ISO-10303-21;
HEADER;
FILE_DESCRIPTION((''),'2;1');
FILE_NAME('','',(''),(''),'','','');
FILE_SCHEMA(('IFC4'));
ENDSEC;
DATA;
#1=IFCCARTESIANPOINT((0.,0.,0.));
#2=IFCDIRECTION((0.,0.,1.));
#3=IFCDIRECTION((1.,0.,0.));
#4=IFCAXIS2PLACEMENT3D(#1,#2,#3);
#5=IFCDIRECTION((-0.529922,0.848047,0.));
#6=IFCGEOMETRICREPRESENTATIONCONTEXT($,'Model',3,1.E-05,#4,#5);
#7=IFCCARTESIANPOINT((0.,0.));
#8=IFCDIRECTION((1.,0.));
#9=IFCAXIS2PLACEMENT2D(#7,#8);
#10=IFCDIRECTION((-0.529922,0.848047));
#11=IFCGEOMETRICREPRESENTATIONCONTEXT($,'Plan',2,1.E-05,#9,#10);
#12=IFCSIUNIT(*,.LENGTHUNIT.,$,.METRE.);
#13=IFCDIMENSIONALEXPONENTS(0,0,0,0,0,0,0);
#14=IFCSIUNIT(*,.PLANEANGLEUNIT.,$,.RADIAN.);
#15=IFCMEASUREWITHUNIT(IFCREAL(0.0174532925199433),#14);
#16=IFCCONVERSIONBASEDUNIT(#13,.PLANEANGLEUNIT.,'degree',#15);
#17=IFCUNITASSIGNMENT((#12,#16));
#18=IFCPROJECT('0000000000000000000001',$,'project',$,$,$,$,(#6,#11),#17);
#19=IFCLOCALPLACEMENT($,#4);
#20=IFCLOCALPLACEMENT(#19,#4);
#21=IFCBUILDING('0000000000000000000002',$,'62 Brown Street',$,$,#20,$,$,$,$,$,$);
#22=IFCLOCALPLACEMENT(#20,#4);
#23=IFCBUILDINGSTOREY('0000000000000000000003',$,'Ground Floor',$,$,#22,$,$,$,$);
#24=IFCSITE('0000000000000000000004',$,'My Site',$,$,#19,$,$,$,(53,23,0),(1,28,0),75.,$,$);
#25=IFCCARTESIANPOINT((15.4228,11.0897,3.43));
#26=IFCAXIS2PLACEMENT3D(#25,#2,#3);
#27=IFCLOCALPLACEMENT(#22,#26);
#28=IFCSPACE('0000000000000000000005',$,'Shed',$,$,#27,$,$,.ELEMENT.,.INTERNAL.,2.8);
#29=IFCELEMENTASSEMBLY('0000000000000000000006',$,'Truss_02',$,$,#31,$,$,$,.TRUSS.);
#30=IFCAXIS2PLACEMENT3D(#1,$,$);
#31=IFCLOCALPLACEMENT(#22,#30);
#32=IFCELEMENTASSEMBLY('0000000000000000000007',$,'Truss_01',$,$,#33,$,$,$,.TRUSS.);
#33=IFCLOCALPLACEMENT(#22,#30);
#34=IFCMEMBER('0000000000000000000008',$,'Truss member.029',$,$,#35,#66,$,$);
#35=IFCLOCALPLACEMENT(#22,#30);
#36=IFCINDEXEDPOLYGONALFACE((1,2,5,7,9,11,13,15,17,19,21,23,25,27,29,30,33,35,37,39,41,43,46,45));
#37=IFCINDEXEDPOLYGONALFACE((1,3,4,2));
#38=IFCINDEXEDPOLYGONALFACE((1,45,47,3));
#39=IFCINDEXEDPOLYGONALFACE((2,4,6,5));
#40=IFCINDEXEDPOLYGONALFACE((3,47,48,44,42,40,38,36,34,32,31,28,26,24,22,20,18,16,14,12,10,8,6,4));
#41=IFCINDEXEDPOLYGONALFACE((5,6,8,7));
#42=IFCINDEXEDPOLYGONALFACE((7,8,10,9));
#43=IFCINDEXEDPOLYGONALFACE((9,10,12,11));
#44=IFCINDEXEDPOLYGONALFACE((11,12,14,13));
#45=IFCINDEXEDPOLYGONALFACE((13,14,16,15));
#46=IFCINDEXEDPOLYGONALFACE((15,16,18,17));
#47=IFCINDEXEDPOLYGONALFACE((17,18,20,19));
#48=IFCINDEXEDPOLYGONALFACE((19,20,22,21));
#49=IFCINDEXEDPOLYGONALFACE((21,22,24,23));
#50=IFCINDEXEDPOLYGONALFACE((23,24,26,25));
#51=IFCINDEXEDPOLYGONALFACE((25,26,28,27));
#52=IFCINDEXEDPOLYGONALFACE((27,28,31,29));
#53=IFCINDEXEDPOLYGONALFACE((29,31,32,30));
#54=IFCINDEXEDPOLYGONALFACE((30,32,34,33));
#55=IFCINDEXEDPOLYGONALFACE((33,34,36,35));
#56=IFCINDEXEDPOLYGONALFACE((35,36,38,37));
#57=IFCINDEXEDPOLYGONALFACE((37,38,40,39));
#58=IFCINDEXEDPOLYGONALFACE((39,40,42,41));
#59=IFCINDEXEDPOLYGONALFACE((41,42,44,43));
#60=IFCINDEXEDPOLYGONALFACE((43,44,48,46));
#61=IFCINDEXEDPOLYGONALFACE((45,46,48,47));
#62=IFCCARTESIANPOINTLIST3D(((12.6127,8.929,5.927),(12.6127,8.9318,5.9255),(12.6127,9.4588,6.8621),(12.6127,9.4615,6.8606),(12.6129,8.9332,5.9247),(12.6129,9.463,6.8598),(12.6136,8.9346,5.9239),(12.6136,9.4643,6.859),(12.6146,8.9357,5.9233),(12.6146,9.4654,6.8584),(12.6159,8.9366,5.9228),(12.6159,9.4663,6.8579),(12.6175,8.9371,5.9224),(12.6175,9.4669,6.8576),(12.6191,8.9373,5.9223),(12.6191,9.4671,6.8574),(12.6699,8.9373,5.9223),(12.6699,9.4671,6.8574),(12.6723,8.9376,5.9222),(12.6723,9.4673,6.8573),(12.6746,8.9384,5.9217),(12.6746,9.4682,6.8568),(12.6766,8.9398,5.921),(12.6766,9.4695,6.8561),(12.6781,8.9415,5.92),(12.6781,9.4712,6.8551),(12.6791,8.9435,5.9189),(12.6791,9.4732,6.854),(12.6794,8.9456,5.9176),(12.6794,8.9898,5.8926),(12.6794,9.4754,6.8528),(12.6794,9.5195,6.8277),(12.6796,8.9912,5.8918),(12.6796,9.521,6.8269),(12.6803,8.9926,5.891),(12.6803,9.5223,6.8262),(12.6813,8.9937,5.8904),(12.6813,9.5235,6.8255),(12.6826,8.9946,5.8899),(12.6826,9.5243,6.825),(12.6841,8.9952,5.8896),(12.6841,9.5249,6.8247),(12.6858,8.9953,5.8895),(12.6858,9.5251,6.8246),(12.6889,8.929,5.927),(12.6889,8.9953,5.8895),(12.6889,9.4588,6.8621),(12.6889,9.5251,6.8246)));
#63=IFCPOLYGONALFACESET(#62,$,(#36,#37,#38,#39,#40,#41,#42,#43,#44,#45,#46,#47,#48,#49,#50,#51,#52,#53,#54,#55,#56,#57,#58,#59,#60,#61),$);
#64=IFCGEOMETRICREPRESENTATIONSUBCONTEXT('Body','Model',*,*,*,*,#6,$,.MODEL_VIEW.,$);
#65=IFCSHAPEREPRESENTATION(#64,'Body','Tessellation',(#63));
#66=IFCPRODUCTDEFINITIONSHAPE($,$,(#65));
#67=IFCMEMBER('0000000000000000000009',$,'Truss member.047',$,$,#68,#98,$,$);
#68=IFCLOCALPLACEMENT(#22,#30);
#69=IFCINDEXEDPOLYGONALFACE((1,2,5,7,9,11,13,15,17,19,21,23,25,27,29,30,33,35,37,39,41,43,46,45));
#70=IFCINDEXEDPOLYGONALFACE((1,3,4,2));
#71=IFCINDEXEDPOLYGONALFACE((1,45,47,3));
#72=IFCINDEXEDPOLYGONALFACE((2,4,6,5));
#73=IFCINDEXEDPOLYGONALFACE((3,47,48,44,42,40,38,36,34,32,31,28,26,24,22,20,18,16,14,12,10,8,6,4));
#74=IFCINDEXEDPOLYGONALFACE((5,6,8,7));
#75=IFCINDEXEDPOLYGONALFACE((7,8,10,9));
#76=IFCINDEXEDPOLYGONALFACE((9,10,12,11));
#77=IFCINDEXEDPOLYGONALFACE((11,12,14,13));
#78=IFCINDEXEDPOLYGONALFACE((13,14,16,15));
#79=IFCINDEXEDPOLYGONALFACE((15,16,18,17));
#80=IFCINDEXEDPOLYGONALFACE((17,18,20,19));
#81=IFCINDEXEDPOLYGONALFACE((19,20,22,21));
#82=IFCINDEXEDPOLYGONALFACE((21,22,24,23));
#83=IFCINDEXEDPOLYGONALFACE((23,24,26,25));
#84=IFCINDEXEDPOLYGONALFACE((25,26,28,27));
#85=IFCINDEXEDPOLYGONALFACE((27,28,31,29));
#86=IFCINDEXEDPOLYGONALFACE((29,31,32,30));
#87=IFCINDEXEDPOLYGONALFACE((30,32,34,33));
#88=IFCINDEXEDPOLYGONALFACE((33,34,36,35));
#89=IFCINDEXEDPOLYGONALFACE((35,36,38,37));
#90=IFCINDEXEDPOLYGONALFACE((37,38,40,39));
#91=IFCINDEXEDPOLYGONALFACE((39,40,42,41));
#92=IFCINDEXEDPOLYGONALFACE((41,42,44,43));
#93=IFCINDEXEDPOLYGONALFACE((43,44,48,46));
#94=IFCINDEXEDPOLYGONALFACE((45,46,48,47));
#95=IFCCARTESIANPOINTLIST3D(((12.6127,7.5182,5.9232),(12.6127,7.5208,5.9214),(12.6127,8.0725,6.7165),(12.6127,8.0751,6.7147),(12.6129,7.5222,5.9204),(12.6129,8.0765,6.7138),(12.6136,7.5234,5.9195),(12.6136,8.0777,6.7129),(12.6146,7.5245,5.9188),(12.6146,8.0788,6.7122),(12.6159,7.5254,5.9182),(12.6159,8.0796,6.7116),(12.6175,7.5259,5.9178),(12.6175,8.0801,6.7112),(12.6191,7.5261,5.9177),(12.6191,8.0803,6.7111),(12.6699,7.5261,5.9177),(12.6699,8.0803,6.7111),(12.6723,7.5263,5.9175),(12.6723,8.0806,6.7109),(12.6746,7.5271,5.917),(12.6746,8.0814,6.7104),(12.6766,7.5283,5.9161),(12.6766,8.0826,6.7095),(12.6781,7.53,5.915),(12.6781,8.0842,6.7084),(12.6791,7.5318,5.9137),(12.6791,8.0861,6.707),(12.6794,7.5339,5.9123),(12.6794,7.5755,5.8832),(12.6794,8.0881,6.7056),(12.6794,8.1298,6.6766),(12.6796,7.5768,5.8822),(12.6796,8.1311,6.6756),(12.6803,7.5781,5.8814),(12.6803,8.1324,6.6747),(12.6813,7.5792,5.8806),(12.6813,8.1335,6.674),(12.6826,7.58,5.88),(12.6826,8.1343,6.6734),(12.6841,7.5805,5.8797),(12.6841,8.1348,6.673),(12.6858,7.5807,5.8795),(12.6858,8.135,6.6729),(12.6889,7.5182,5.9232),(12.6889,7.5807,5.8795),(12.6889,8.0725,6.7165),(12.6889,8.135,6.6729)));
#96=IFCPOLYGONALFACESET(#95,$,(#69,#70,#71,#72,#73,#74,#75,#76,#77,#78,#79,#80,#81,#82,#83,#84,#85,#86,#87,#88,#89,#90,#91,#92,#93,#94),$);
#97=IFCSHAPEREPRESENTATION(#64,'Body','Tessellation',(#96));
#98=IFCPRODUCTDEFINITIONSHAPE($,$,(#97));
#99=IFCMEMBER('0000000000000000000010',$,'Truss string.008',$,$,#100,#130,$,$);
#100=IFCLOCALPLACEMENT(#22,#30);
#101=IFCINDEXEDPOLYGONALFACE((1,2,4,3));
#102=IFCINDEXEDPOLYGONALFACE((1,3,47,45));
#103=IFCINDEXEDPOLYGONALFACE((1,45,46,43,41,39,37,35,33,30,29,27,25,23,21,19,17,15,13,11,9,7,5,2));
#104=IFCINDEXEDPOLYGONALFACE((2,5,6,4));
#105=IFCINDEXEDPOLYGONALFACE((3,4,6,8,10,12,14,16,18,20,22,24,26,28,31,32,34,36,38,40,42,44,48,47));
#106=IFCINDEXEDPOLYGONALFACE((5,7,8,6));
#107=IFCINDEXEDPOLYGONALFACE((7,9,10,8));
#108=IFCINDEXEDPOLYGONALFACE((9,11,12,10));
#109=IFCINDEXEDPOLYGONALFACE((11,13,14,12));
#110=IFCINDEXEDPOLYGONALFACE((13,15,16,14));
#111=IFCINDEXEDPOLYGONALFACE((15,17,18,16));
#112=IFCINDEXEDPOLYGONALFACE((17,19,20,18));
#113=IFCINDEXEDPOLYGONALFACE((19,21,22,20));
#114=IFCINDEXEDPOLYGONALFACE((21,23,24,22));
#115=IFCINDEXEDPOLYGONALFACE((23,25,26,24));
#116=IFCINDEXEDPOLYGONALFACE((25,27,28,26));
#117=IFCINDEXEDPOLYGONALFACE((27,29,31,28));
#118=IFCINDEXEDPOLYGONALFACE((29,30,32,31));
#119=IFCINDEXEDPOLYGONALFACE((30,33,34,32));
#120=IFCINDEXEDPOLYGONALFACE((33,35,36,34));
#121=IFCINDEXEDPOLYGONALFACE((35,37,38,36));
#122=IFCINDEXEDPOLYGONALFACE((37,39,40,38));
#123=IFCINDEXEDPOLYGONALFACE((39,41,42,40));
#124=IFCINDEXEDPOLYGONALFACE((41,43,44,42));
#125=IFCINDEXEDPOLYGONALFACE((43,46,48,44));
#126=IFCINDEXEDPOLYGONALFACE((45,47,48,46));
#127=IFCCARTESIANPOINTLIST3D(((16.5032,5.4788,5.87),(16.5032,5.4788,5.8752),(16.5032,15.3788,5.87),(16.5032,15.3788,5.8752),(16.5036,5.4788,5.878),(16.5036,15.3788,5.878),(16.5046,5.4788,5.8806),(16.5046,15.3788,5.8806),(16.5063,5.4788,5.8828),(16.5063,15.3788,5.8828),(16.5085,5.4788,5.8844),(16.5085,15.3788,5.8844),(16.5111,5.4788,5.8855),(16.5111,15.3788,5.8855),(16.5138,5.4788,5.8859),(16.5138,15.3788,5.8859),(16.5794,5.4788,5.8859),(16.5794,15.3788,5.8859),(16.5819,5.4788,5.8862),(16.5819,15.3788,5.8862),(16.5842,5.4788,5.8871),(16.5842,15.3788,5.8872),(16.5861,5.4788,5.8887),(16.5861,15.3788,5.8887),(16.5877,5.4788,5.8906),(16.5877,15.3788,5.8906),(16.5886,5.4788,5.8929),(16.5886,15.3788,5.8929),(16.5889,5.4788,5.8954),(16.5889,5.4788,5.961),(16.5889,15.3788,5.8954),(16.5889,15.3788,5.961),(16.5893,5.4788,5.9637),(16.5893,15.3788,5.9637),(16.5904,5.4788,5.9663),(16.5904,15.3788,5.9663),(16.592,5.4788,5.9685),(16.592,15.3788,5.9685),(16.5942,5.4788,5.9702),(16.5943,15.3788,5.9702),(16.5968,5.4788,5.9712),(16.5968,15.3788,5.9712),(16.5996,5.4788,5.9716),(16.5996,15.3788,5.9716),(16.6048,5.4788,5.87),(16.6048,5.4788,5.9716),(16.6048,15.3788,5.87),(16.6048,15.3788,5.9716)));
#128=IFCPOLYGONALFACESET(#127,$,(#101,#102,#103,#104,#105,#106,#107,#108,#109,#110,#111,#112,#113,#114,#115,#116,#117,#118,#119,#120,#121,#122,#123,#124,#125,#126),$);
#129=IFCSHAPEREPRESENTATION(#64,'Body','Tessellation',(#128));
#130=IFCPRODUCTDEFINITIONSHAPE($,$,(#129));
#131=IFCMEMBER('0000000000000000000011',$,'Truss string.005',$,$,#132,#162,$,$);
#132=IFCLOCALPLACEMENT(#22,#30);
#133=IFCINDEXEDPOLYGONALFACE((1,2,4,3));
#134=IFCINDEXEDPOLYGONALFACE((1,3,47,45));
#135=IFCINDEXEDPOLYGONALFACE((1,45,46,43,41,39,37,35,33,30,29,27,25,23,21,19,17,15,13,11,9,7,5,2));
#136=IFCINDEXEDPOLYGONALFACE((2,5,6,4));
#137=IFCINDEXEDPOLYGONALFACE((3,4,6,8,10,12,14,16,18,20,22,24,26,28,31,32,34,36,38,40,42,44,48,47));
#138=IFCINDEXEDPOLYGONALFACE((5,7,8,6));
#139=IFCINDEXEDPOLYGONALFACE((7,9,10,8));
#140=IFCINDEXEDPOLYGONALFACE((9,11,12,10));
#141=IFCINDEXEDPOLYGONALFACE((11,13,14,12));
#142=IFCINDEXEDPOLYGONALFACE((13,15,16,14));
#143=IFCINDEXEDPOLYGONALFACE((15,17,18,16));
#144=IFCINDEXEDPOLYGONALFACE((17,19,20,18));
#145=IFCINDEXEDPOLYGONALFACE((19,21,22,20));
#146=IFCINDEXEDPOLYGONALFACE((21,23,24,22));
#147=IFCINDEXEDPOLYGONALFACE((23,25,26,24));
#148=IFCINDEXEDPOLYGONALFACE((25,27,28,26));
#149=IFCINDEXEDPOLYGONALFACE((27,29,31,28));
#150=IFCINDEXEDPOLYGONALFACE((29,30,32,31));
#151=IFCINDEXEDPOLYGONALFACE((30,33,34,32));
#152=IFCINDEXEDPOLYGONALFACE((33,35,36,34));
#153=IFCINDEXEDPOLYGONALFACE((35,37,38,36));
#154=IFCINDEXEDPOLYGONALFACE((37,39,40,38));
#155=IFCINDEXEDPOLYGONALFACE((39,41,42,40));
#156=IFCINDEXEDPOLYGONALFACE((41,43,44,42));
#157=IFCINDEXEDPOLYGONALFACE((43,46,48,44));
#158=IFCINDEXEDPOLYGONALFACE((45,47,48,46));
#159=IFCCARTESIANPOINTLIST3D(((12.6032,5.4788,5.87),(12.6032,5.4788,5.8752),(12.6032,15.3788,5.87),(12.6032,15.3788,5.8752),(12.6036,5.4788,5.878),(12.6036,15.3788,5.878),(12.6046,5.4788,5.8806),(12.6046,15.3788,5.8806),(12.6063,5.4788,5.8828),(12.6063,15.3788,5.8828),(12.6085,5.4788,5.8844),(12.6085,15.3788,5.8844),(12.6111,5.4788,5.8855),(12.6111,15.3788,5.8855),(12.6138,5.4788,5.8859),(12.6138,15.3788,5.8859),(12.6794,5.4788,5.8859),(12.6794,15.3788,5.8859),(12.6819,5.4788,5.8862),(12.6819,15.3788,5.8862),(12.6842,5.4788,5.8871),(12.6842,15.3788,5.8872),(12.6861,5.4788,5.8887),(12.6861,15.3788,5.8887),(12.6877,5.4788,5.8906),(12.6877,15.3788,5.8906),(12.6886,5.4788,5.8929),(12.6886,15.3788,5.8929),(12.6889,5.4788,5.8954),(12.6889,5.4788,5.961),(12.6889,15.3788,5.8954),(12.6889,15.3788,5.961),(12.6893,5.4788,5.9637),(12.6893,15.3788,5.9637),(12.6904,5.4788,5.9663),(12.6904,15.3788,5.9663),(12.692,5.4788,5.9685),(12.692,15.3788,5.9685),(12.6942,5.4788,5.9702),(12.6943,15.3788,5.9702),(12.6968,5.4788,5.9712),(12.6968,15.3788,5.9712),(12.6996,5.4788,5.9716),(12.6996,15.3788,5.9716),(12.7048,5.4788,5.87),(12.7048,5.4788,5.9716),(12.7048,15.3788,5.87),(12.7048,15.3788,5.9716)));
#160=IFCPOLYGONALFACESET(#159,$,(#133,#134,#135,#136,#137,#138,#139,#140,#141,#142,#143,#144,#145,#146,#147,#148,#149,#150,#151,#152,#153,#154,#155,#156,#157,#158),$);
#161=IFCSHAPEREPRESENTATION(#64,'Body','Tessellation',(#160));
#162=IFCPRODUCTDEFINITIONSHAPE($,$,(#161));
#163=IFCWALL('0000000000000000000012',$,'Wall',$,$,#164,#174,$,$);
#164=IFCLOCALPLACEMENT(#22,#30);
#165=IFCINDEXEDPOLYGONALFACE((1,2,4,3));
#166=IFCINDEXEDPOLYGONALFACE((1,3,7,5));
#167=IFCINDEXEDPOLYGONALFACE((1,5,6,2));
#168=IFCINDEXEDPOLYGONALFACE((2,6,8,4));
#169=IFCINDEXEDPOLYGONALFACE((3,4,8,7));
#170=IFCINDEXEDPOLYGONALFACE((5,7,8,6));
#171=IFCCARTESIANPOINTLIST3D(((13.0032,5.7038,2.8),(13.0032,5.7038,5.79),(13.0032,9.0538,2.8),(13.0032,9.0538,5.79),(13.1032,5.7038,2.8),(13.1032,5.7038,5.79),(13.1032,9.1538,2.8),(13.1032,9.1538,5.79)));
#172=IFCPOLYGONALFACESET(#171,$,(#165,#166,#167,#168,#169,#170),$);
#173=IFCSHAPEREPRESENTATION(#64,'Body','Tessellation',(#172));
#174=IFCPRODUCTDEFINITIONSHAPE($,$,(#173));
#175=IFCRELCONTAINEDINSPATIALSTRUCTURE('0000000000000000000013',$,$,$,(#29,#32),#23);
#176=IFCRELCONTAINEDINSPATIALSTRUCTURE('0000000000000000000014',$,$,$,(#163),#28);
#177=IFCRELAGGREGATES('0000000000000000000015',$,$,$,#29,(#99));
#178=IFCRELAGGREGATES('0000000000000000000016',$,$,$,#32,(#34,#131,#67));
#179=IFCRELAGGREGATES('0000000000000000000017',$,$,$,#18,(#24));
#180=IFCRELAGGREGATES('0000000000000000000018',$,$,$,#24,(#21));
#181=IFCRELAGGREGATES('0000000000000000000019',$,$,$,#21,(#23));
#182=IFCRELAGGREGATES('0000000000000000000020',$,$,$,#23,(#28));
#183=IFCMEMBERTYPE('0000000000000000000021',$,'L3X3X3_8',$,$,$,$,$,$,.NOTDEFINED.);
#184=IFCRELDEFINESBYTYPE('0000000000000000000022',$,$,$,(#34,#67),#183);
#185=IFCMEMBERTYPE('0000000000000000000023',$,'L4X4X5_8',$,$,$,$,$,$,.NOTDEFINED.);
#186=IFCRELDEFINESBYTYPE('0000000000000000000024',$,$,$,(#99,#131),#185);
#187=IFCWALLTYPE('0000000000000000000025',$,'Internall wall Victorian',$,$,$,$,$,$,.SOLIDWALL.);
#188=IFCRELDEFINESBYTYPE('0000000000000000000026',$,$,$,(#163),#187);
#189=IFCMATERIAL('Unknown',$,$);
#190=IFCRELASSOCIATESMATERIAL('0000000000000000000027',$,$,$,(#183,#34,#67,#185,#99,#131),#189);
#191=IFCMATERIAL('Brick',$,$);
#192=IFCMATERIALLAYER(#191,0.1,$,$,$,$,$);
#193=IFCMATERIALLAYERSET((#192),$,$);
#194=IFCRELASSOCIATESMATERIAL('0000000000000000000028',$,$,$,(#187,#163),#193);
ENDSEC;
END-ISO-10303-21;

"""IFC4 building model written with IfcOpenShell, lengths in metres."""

from ifc_helpers import new_model, entity, si_unit, converted_unit, direction, frame, origin_with_axes, origin_2d_with_axis, place, context, subcontext, project, spatial, indexed_curve, l_section, outline, extrude, clip, halfspace, material, layer, layer_set, layer_usage, material_profile, profile_set, profile_usage, type_object, element, aggregate, save


model = new_model("IFC4")

# Units and contexts
model_context = context("Model", 3, precision=1e-05, world=origin_with_axes(), true_north=direction((-0.529922, 0.848047, 0.0)))
plan_context = context("Plan", 2, precision=1e-05, world=origin_2d_with_axis(), true_north=direction((-0.529922, 0.848047)))
body_context_1 = subcontext(model_context, "Body", "Model", "MODEL_VIEW")
ifc_project = project(units=[si_unit("LENGTHUNIT", "METRE"), converted_unit("PLANEANGLEUNIT", "degree", entity("IfcReal", 0.0174532925199433), si_unit("PLANEANGLEUNIT", "RADIAN"), dimensions=[0, 0, 0, 0, 0, 0, 0])], contexts=[model_context, plan_context])

# Site, building, storey
site_placement = place(None, origin_with_axes())
site = spatial("IfcSite", under=ifc_project, at=site_placement, Name="My Site", RefLatitude=(53, 23, 0), RefLongitude=(1, 28, 0), RefElevation=75.0)
building_placement = place(site_placement, origin_with_axes())
building = spatial("IfcBuilding", under=site, at=building_placement, Name="62 Brown Street")
storey_placement = place(building_placement, origin_with_axes())
storey = spatial("IfcBuildingStorey", under=building, at=storey_placement, Name="Ground Floor")

# Element assemblies, members
ifc_material_1 = material(Name="Unknown")
ifc_material_profile_1 = material_profile(ifc_material_1, l_section(Depth=0.0762, Width=0.0762, Thickness=0.0095, FilletRadius=0.0095, EdgeRadius=0.0064))
ifc_profile_set_1 = profile_set([ifc_material_profile_1])
member_type_1 = type_object("IfcMemberType", Name="L3X3X3_8", PredefinedType="NOTDEFINED", material=ifc_profile_set_1)
assembly_1_placement = place(storey_placement, frame((16.6032, 10.4288, 6.9738), z_axis=(0.0, 0.0, 1.0), x_axis=(1.0, 0.0, 0.0)))
assembly_1 = element("IfcElementAssembly", 1, at=assembly_1_placement, inside=storey, Name="Truss_02", PredefinedType="TRUSS")
assembly_2_placement = place(storey_placement, frame((12.7032, 10.4288, 6.9738), z_axis=(0.0, 0.0, 1.0), x_axis=(1.0, 0.0, 0.0)))
assembly_2 = element("IfcElementAssembly", 2, at=assembly_2_placement, inside=storey, Name="Truss_01", PredefinedType="TRUSS")
ifc_profile_usage_1 = profile_usage(ifc_profile_set_1, cardinal=5)
member_1_placement = place(assembly_2_placement, frame((-0.0524, -0.9369, -0.1304), z_axis=(0.0, -0.492899, -0.870086), x_axis=(-1.0, 0.0, 0.0)))
member_1 = element("IfcMember", 3, at=member_1_placement, type_object=member_type_1, material=ifc_profile_usage_1, Name="Truss member.029", context=body_context_1, shape_type="SweptSolid", body=[
    extrude(l_section(Depth=0.0762, Width=0.0762, Thickness=0.0095, FilletRadius=0.0095, EdgeRadius=0.0064), origin_with_axes(), (0.0, 0.0, 1.0), 1.0747),
])
ifc_profile_usage_2 = profile_usage(ifc_profile_set_1, cardinal=5)
member_2_placement = place(assembly_2_placement, frame((-0.0524, -2.325, -0.279), z_axis=(0.000001, -0.572709, -0.819759), x_axis=(-1.0, -0.000001, 0.0)))
member_2 = element("IfcMember", 4, at=member_2_placement, type_object=member_type_1, material=ifc_profile_usage_2, Name="Truss member.047", context=body_context_1, shape_type="SweptSolid", body=[
    extrude(l_section(Depth=0.0762, Width=0.0762, Thickness=0.0095, FilletRadius=0.0095, EdgeRadius=0.0064), origin_with_axes(), (0.0, 0.0, 1.0), 0.9678),
])

# Members
ifc_material_profile_2 = material_profile(ifc_material_1, l_section(Depth=0.1016, Width=0.1016, Thickness=0.0159, FilletRadius=0.0095, EdgeRadius=0.0106))
ifc_profile_set_2 = profile_set([ifc_material_profile_2])
ifc_profile_usage_3 = profile_usage(ifc_profile_set_2, cardinal=5)
member_type_2 = type_object("IfcMemberType", Name="L4X4X5_8", PredefinedType="NOTDEFINED", material=ifc_profile_set_2)
member_3_placement = place(assembly_1_placement, frame((-0.0492, -4.95, -1.053), z_axis=(0.0, 1.0, 0.0), x_axis=(-1.0, 0.0, 0.0)))
member_3 = element("IfcMember", 5, at=member_3_placement, type_object=member_type_2, material=ifc_profile_usage_3, Name="Truss string.008", context=body_context_1, shape_type="SweptSolid", body=[
    extrude(l_section(Depth=0.1016, Width=0.1016, Thickness=0.0159, FilletRadius=0.0095, EdgeRadius=0.0106), origin_with_axes(), (0.0, 0.0, 1.0), 9.9),
])
aggregate(assembly_1, [member_3])
ifc_profile_usage_4 = profile_usage(ifc_profile_set_2, cardinal=5)
member_4_placement = place(assembly_2_placement, frame((-0.0492, -4.95, -1.053), z_axis=(0.0, 1.0, 0.0), x_axis=(-1.0, 0.0, 0.0)))
member_4 = element("IfcMember", 6, at=member_4_placement, type_object=member_type_2, material=ifc_profile_usage_4, Name="Truss string.005", context=body_context_1, shape_type="SweptSolid", body=[
    extrude(l_section(Depth=0.1016, Width=0.1016, Thickness=0.0159, FilletRadius=0.0095, EdgeRadius=0.0106), origin_with_axes(), (0.0, 0.0, 1.0), 9.9),
])
aggregate(assembly_2, [member_1, member_4, member_2])

# Shared definitions
space_placement = place(storey_placement, frame((15.4228, 11.0897, 3.43), z_axis=(0.0, 0.0, 1.0), x_axis=(1.0, 0.0, 0.0)))
space = spatial("IfcSpace", under=storey, at=space_placement, Name="Shed", CompositionType="ELEMENT", PredefinedType="INTERNAL", ElevationWithFlooring=2.8)

# Wall
ifc_material_2 = material(Name="Brick")
ifc_layer_1 = layer(ifc_material_2, 0.1)
ifc_layer_set_1 = layer_set([ifc_layer_1])
ifc_layer_usage_1 = layer_usage(ifc_layer_set_1, "AXIS2", "POSITIVE", 0.0)
wall_type = type_object("IfcWallType", Name="Internall wall Victorian", PredefinedType="SOLIDWALL", material=ifc_layer_set_1)
wall_1_placement = place(None, frame((13.1032, 5.7038, 2.8), z_axis=(0.0, 0.0, 1.0), x_axis=(0.0, 1.0, 0.0)))
element("IfcWall", 7, at=wall_1_placement, inside=space, type_object=wall_type, material=ifc_layer_usage_1, Name="Wall", context=body_context_1, shape_type="Clipping", body=[
    clip(extrude(outline(indexed_curve([(0.0, 0.0), (0.0, 0.1), (3.45, 0.1), (3.45, 0.0), (0.0, 0.0)], self_intersect=False)), origin_with_axes(), (0.0, 0.0, 1.0), 2.99), halfspace(frame((3.45, 0.0, -2.8), z_axis=(0.70711, 0.707104, 0.0), x_axis=(0.707104, -0.70711, 0.0)), False)),
])

save(model, "model.ifc")
